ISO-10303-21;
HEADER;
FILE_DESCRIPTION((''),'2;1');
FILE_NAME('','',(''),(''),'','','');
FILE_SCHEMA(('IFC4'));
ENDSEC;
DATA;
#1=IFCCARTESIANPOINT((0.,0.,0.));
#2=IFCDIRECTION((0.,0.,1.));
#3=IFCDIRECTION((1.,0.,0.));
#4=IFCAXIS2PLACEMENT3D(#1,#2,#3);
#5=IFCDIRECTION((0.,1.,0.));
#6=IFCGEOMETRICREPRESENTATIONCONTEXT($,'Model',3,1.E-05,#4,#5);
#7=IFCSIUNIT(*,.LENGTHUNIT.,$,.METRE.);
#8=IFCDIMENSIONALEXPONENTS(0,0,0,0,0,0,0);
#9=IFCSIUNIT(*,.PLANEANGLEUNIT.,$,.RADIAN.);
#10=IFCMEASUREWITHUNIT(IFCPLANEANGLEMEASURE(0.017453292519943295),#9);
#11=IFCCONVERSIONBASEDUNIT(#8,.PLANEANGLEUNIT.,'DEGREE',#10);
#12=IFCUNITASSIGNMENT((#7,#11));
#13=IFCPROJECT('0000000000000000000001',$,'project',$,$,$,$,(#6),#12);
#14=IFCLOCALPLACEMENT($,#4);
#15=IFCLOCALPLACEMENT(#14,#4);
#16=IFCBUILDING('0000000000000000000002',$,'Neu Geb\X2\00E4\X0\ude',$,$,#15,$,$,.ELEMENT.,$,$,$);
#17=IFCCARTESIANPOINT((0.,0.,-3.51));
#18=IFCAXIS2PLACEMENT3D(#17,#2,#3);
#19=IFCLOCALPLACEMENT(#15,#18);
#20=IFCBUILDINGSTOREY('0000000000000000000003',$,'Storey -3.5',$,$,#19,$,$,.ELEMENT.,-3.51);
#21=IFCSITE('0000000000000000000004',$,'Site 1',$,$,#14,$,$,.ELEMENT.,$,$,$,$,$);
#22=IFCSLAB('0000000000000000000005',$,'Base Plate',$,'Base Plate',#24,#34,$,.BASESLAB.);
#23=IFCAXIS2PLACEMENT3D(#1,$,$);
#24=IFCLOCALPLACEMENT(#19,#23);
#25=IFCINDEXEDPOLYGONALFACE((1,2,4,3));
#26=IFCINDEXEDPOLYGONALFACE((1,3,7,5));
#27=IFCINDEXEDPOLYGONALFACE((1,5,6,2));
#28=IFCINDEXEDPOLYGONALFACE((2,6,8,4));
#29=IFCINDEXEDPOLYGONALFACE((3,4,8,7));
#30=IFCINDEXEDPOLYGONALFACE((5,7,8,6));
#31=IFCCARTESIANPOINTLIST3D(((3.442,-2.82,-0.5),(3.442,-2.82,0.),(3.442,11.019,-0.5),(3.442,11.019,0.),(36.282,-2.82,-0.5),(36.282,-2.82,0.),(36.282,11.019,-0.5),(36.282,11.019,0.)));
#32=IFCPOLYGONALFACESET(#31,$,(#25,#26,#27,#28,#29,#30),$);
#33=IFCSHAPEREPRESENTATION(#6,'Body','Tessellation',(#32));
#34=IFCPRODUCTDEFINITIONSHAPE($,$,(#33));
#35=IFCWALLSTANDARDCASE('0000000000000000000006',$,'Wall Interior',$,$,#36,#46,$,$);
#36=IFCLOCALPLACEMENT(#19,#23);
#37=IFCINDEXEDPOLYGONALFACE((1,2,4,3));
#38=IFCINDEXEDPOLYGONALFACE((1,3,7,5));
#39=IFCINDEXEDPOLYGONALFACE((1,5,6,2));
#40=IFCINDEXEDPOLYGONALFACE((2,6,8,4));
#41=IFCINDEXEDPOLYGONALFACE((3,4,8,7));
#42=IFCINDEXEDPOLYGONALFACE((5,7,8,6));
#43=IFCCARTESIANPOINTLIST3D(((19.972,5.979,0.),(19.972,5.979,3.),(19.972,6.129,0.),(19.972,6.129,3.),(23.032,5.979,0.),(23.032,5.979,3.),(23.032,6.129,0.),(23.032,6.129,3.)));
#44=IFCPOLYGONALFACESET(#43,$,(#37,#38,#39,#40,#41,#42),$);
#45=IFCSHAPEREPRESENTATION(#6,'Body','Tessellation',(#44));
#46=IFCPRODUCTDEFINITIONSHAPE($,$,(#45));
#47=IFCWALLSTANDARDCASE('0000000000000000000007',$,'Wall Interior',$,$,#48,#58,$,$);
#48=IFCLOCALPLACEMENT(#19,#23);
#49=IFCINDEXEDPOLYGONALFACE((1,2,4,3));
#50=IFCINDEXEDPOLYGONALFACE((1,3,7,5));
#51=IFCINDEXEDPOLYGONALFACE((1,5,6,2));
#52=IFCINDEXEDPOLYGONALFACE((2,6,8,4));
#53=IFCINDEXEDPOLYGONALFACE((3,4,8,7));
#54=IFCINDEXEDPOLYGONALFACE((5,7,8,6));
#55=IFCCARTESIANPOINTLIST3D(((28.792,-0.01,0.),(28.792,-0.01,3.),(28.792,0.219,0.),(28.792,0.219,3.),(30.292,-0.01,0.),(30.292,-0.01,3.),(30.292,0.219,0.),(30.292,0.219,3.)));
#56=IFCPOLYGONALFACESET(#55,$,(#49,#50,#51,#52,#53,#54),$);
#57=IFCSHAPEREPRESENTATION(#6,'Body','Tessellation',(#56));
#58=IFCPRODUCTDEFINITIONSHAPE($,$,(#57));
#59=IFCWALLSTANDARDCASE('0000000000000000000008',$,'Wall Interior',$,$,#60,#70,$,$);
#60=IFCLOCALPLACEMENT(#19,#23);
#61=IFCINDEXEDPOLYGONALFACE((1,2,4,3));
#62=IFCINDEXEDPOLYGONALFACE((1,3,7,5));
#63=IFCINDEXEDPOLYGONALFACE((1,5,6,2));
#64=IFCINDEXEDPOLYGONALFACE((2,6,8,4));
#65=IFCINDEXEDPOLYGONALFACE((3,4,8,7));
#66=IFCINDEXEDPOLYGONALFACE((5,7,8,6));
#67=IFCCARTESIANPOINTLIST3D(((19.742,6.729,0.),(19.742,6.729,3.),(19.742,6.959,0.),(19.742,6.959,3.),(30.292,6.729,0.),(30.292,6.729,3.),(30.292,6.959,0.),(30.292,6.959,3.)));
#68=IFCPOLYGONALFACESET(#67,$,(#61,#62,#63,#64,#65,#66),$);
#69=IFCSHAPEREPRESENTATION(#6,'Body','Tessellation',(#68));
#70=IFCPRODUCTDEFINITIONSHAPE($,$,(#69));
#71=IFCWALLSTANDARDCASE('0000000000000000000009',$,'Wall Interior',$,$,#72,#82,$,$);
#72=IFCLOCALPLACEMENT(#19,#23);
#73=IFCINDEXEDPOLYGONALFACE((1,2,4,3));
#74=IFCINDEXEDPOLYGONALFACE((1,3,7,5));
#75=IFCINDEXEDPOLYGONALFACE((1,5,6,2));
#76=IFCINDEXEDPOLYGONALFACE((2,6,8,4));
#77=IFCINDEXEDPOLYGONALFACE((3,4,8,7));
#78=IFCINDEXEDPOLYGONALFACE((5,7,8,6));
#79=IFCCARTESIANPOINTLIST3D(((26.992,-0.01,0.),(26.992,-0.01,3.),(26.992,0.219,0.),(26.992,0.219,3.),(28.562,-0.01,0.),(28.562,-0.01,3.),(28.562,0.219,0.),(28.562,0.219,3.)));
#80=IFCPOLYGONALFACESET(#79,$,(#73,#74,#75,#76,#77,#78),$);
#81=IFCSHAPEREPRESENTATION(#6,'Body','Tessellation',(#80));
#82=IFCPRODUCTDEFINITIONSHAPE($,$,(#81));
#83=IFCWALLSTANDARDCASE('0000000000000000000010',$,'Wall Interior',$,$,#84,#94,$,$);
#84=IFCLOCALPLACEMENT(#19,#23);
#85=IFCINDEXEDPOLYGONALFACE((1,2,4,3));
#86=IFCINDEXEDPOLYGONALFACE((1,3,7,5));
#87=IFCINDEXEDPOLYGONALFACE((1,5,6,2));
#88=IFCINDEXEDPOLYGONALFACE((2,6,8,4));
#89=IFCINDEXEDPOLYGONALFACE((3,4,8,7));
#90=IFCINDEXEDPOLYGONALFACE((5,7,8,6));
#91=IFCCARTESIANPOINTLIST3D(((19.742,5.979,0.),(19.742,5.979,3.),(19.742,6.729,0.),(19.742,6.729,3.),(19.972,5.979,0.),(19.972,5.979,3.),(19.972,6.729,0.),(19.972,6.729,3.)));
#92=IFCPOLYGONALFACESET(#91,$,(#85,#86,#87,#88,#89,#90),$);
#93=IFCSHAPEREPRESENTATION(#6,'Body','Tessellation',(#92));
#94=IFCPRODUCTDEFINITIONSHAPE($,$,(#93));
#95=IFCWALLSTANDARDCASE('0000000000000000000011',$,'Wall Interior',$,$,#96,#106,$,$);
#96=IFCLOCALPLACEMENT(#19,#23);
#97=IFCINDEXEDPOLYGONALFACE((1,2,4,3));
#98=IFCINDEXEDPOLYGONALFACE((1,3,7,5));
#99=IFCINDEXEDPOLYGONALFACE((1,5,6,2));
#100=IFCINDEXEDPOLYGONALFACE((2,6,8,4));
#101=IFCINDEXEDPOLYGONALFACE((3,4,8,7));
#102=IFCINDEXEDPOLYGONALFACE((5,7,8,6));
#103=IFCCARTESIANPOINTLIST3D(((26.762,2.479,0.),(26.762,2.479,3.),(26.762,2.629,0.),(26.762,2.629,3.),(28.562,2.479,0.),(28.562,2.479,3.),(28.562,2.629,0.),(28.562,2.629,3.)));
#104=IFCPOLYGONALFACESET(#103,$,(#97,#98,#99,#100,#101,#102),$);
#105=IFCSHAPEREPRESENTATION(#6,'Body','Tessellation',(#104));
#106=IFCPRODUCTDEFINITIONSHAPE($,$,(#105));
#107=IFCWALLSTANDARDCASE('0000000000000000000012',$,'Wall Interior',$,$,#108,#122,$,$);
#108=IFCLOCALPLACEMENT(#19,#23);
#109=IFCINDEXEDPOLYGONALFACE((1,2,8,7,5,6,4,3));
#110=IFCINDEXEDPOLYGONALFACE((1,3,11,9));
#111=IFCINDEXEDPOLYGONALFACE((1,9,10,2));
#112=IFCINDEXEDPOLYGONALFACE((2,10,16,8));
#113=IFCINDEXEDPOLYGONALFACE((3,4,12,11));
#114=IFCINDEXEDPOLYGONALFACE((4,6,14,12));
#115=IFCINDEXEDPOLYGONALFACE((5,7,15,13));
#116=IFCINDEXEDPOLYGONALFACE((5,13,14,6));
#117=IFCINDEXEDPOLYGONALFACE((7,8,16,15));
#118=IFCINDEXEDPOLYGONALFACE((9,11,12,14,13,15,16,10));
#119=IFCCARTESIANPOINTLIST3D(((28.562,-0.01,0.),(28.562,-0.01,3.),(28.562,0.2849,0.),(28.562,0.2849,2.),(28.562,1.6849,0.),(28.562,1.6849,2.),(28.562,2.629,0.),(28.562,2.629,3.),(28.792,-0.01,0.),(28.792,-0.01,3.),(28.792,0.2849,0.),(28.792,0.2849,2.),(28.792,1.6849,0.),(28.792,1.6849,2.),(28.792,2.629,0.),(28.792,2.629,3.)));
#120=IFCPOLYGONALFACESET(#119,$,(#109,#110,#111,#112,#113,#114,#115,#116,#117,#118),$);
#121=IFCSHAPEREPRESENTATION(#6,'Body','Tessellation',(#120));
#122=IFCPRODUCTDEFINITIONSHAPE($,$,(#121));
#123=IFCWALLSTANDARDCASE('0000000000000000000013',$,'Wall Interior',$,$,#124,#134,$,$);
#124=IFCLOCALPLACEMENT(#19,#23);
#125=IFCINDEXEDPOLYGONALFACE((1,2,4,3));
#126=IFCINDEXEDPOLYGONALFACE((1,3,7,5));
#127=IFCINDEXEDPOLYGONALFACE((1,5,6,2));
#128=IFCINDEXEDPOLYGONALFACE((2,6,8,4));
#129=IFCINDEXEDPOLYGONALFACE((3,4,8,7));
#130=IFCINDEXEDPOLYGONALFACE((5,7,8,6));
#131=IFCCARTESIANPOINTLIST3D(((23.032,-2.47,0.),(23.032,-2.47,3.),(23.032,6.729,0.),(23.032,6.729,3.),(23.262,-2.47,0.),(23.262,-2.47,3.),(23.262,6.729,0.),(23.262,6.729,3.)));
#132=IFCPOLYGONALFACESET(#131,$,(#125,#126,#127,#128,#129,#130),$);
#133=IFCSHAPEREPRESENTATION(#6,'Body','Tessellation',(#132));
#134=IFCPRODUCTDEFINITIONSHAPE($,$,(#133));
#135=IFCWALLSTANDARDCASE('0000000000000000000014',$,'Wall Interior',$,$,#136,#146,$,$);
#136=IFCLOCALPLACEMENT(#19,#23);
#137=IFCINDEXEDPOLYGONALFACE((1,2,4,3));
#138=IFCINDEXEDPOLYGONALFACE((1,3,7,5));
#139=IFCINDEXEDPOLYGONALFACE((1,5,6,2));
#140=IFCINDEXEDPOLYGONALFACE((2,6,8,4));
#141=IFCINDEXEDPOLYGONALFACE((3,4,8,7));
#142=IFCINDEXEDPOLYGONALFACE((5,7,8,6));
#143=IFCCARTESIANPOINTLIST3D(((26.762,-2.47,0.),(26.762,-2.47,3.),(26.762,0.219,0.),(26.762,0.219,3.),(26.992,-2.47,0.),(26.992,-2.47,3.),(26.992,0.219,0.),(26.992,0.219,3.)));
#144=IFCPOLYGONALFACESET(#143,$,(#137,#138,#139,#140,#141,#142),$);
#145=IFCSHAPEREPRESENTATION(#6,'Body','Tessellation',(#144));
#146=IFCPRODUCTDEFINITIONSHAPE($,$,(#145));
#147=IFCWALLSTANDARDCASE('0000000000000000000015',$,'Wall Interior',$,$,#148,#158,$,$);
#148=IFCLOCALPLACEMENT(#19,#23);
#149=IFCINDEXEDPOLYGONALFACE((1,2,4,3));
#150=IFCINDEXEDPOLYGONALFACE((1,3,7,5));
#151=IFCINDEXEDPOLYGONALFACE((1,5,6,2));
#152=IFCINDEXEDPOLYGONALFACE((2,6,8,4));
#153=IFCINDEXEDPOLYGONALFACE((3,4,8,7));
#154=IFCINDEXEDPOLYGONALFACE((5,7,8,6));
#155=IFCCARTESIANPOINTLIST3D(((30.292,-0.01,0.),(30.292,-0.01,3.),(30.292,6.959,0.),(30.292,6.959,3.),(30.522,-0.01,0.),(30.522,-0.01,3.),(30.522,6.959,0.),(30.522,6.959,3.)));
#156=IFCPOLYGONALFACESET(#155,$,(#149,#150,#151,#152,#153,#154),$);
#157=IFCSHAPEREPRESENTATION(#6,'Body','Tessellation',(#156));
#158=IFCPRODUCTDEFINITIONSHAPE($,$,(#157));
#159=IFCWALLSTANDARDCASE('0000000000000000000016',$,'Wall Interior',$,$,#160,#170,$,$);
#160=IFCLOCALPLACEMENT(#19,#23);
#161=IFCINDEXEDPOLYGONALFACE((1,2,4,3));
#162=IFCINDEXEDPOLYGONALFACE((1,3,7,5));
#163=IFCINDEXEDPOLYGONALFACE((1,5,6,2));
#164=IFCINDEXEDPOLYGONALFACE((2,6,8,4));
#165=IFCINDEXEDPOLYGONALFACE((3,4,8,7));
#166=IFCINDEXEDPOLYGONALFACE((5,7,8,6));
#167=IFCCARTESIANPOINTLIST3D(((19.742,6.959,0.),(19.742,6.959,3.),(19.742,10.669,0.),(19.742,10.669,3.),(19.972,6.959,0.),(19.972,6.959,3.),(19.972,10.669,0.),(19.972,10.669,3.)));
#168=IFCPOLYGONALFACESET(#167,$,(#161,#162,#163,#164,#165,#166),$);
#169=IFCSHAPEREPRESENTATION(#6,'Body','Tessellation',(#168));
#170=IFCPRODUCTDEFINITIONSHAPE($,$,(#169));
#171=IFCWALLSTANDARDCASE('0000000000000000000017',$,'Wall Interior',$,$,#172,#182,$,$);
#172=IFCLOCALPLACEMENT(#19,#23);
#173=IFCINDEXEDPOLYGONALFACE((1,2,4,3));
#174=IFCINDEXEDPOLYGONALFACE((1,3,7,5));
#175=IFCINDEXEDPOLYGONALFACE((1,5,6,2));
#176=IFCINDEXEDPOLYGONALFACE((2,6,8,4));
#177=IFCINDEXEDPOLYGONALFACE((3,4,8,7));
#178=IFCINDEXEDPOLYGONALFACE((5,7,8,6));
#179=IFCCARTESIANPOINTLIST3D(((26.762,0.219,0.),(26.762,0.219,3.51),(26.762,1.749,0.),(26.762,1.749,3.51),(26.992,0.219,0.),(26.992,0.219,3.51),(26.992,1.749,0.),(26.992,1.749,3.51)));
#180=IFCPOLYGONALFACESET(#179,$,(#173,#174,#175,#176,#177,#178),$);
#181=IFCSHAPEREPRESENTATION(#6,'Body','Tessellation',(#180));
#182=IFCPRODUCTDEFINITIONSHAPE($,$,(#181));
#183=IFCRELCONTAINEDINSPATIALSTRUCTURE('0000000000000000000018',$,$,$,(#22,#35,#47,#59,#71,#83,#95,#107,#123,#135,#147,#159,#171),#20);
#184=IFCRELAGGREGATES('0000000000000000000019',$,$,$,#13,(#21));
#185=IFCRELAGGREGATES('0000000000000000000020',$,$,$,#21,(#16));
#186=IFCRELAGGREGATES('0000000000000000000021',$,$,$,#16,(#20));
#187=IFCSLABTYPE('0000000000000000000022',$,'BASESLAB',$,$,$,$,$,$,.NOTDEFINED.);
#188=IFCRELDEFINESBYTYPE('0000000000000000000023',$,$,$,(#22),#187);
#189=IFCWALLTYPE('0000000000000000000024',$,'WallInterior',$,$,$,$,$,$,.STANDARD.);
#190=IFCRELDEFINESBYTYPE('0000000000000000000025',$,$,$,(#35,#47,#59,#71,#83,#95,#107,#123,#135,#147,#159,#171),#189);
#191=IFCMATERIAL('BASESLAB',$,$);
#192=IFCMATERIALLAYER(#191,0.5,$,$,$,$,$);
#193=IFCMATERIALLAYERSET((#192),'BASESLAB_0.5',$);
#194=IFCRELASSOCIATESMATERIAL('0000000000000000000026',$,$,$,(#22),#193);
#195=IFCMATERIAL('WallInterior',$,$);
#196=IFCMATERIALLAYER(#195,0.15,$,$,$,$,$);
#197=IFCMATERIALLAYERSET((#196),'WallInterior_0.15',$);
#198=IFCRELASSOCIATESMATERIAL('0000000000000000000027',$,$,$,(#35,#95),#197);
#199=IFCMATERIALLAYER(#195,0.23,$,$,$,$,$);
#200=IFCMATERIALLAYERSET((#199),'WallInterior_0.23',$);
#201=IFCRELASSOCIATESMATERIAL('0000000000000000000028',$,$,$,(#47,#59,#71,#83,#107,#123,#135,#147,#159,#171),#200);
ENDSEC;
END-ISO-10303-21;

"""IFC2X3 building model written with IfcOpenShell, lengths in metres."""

from ifc_helpers import new_model, entity, si_unit, converted_unit, direction, frame, origin_with_axes, place, context, project, spatial, polyline, outline, extrude, material, layer, layer_set, layer_usage, type_object, element, save


model = new_model("IFC2X3")

# Units and contexts
model_context = context("Model", 3, precision=1e-05, world=origin_with_axes(), true_north=direction((0.0, 1.0, 0.0)))
ifc_project = project(units=[si_unit("LENGTHUNIT", "METRE"), converted_unit("PLANEANGLEUNIT", "DEGREE", entity("IfcPlaneAngleMeasure", 0.017453292519943295), si_unit("PLANEANGLEUNIT", "RADIAN"), dimensions=[0, 0, 0, 0, 0, 0, 0])], contexts=[model_context])

# Site, building, storey
site_placement = place(None, origin_with_axes())
site = spatial("IfcSite", under=ifc_project, at=site_placement, Name="Site 1", CompositionType="ELEMENT")
building_placement = place(site_placement, origin_with_axes())
building = spatial("IfcBuilding", under=site, at=building_placement, Name="Neu Gebäude", CompositionType="ELEMENT")
storey_placement = place(building_placement, frame((0.0, 0.0, -3.51), z_axis=(0.0, 0.0, 1.0), x_axis=(1.0, 0.0, 0.0)))
storey = spatial("IfcBuildingStorey", under=building, at=storey_placement, Name="Storey -3.5", CompositionType="ELEMENT", Elevation=-3.51)

# Slab
ifc_material_1 = material(Name="BASESLAB")
ifc_layer_1 = layer(ifc_material_1, 0.5)
ifc_layer_set_1 = layer_set([ifc_layer_1], Name="BASESLAB_0.5")
ifc_layer_usage_1 = layer_usage(ifc_layer_set_1, "AXIS2", "POSITIVE", 0.5)
slab_type = type_object("IfcSlabType", Name="BASESLAB")
slab_placement = place(storey_placement, frame((0.0, 0.0, -0.5), z_axis=(0.0, 0.0, 1.0), x_axis=(1.0, 0.0, 0.0)))
element("IfcSlab", 1, at=slab_placement, inside=storey, type_object=slab_type, material=ifc_layer_usage_1, Name="Base Plate", ObjectType="Base Plate", PredefinedType="BASESLAB", context=model_context, shape_type="SweptSolid", body=[
    extrude(outline(polyline([(36.282, 11.019), (3.442, 11.019), (3.442, -2.82), (36.282, -2.82), (36.282, 11.019)])), origin_with_axes(), (0.0, 0.0, 1.0), 0.5),
])

# Walls
ifc_material_2 = material(Name="WallInterior")
ifc_layer_2 = layer(ifc_material_2, 0.15)
ifc_layer_set_2 = layer_set([ifc_layer_2], Name="WallInterior_0.15")
ifc_layer_usage_2 = layer_usage(ifc_layer_set_2, "AXIS2", "POSITIVE", -0.075)
wall_type_1 = type_object("IfcWallType", Name="WallInterior", PredefinedType="STANDARD")
wall_1_placement = place(storey_placement, frame((23.032, 6.054, 0.0), z_axis=(0.0, 0.0, 1.0), x_axis=(-1.0, 0.0, 0.0)))
element("IfcWallStandardCase", 2, at=wall_1_placement, inside=storey, type_object=wall_type_1, material=ifc_layer_usage_2, Name="Wall Interior", context=model_context, shape_type="SweptSolid", body=[
    extrude(outline(polyline([(0.0, 0.075), (0.0, -0.075), (3.06, -0.075), (3.06, 0.075), (0.0, 0.075)])), origin_with_axes(), (0.0, 0.0, 1.0), 3.0),
])
ifc_layer_3 = layer(ifc_material_2, 0.23)
ifc_layer_set_3 = layer_set([ifc_layer_3], Name="WallInterior_0.23")
ifc_layer_usage_3 = layer_usage(ifc_layer_set_3, "AXIS2", "POSITIVE", -0.115)
wall_2_placement = place(storey_placement, frame((30.292, 0.1045, 0.0), z_axis=(0.0, 0.0, 1.0), x_axis=(-1.0, 0.0, 0.0)))
element("IfcWallStandardCase", 3, at=wall_2_placement, inside=storey, type_object=wall_type_1, material=ifc_layer_usage_3, Name="Wall Interior", context=model_context, shape_type="SweptSolid", body=[
    extrude(outline(polyline([(0.0, -0.1145), (1.5, -0.1145), (1.5, 0.1145), (0.0, 0.1145), (0.0, -0.1145)])), origin_with_axes(), (0.0, 0.0, 1.0), 3.0),
])
wall_3_placement = place(storey_placement, frame((30.292, 6.844, 0.0), z_axis=(0.0, 0.0, 1.0), x_axis=(-1.0, 0.0, 0.0)))
element("IfcWallStandardCase", 4, at=wall_3_placement, inside=storey, type_object=wall_type_1, material=ifc_layer_usage_3, Name="Wall Interior", context=model_context, shape_type="SweptSolid", body=[
    extrude(outline(polyline([(0.0, -0.115), (10.55, -0.115), (10.55, 0.115), (0.0, 0.115), (0.0, -0.115)])), origin_with_axes(), (0.0, 0.0, 1.0), 3.0),
])
wall_4_placement = place(storey_placement, frame((28.562, 0.1045, 0.0), z_axis=(0.0, 0.0, 1.0), x_axis=(-1.0, 0.0, 0.0)))
element("IfcWallStandardCase", 5, at=wall_4_placement, inside=storey, type_object=wall_type_1, material=ifc_layer_usage_3, Name="Wall Interior", context=model_context, shape_type="SweptSolid", body=[
    extrude(outline(polyline([(0.0, -0.1145), (1.57, -0.1145), (1.57, 0.1145), (0.0, 0.1145), (0.0, -0.1145)])), origin_with_axes(), (0.0, 0.0, 1.0), 3.0),
])
wall_5_placement = place(storey_placement, frame((19.857, 5.979, 0.0), z_axis=(0.0, 0.0, 1.0), x_axis=(0.0, 1.0, 0.0)))
element("IfcWallStandardCase", 6, at=wall_5_placement, inside=storey, type_object=wall_type_1, material=ifc_layer_usage_3, Name="Wall Interior", context=model_context, shape_type="SweptSolid", body=[
    extrude(outline(polyline([(0.75, -0.115), (0.75, 0.115), (0.0, 0.115), (0.0, -0.115), (0.75, -0.115)])), origin_with_axes(), (0.0, 0.0, 1.0), 3.0),
])
wall_6_placement = place(storey_placement, frame((28.562, 2.554, 0.0), z_axis=(0.0, 0.0, 1.0), x_axis=(-1.0, 0.0, 0.0)))
element("IfcWallStandardCase", 7, at=wall_6_placement, inside=storey, type_object=wall_type_1, material=ifc_layer_usage_2, Name="Wall Interior", context=model_context, shape_type="SweptSolid", body=[
    extrude(outline(polyline([(0.0, -0.075), (1.8, -0.075), (1.8, 0.075), (0.0, 0.075), (0.0, -0.075)])), origin_with_axes(), (0.0, 0.0, 1.0), 3.0),
])

# Wall, opening
wall_7_placement = place(storey_placement, frame((28.677, -0.01, 0.0), z_axis=(0.0, 0.0, 1.0), x_axis=(0.0, 1.0, 0.0)))
wall_7 = element("IfcWallStandardCase", 8, at=wall_7_placement, inside=storey, type_object=wall_type_1, material=ifc_layer_usage_3, Name="Wall Interior", context=model_context, shape_type="SweptSolid", body=[
    extrude(outline(polyline([(2.639, -0.115), (2.639, 0.115), (0.0, 0.115), (0.0, -0.115), (2.639, -0.115)])), origin_with_axes(), (0.0, 0.0, 1.0), 3.0),
])
opening_placement = place(wall_7_placement, frame((0.9949, 0.0, 0.0), z_axis=(0.0, 0.0, 1.0), x_axis=(1.0, 0.0, 0.0)))
element("IfcOpeningElement", 9, at=opening_placement, cuts=wall_7, context=model_context, shape_type="SweptSolid", body=[
    extrude(outline(polyline([(-0.7, 0.252), (0.7, 0.252), (0.7, -0.252), (-0.7, -0.252), (-0.7, 0.252)])), origin_with_axes(), (0.0, 0.0, 1.0), 2.0),
])

# Walls
wall_8_placement = place(storey_placement, frame((23.147, -2.47, 0.0), z_axis=(0.0, 0.0, 1.0), x_axis=(0.0, 1.0, 0.0)))
element("IfcWallStandardCase", 10, at=wall_8_placement, inside=storey, type_object=wall_type_1, material=ifc_layer_usage_3, Name="Wall Interior", context=model_context, shape_type="SweptSolid", body=[
    extrude(outline(polyline([(9.199, -0.115), (9.199, 0.115), (0.0, 0.115), (0.0, -0.115), (9.199, -0.115)])), origin_with_axes(), (0.0, 0.0, 1.0), 3.0),
])
wall_9_placement = place(storey_placement, frame((26.877, -2.47, 0.0), z_axis=(0.0, 0.0, 1.0), x_axis=(0.0, 1.0, 0.0)))
element("IfcWallStandardCase", 11, at=wall_9_placement, inside=storey, type_object=wall_type_1, material=ifc_layer_usage_3, Name="Wall Interior", context=model_context, shape_type="SweptSolid", body=[
    extrude(outline(polyline([(2.689, -0.115), (2.689, 0.115), (0.0, 0.115), (0.0, -0.115), (2.689, -0.115)])), origin_with_axes(), (0.0, 0.0, 1.0), 3.0),
])
wall_10_placement = place(storey_placement, frame((30.407, -0.01, 0.0), z_axis=(0.0, 0.0, 1.0), x_axis=(0.0, 1.0, 0.0)))
element("IfcWallStandardCase", 12, at=wall_10_placement, inside=storey, type_object=wall_type_1, material=ifc_layer_usage_3, Name="Wall Interior", context=model_context, shape_type="SweptSolid", body=[
    extrude(outline(polyline([(6.969, -0.115), (6.969, 0.115), (0.0, 0.115), (0.0, -0.115), (6.969, -0.115)])), origin_with_axes(), (0.0, 0.0, 1.0), 3.0),
])
wall_11_placement = place(storey_placement, frame((19.857, 6.959, 0.0), z_axis=(0.0, 0.0, 1.0), x_axis=(0.0, 1.0, 0.0)))
element("IfcWallStandardCase", 13, at=wall_11_placement, inside=storey, type_object=wall_type_1, material=ifc_layer_usage_3, Name="Wall Interior", context=model_context, shape_type="SweptSolid", body=[
    extrude(outline(polyline([(3.71, -0.115), (3.71, 0.115), (0.0, 0.115), (0.0, -0.115), (3.71, -0.115)])), origin_with_axes(), (0.0, 0.0, 1.0), 3.0),
])
wall_12_placement = place(storey_placement, frame((26.877, 0.219, 0.0), z_axis=(0.0, 0.0, 1.0), x_axis=(0.0, 1.0, 0.0)))
element("IfcWallStandardCase", 14, at=wall_12_placement, inside=storey, type_object=wall_type_1, material=ifc_layer_usage_3, Name="Wall Interior", context=model_context, shape_type="SweptSolid", body=[
    extrude(outline(polyline([(1.53, -0.115), (1.53, 0.115), (0.0, 0.115), (0.0, -0.115), (1.53, -0.115)])), origin_with_axes(), (0.0, 0.0, 1.0), 3.51),
])

save(model, "model.ifc")
